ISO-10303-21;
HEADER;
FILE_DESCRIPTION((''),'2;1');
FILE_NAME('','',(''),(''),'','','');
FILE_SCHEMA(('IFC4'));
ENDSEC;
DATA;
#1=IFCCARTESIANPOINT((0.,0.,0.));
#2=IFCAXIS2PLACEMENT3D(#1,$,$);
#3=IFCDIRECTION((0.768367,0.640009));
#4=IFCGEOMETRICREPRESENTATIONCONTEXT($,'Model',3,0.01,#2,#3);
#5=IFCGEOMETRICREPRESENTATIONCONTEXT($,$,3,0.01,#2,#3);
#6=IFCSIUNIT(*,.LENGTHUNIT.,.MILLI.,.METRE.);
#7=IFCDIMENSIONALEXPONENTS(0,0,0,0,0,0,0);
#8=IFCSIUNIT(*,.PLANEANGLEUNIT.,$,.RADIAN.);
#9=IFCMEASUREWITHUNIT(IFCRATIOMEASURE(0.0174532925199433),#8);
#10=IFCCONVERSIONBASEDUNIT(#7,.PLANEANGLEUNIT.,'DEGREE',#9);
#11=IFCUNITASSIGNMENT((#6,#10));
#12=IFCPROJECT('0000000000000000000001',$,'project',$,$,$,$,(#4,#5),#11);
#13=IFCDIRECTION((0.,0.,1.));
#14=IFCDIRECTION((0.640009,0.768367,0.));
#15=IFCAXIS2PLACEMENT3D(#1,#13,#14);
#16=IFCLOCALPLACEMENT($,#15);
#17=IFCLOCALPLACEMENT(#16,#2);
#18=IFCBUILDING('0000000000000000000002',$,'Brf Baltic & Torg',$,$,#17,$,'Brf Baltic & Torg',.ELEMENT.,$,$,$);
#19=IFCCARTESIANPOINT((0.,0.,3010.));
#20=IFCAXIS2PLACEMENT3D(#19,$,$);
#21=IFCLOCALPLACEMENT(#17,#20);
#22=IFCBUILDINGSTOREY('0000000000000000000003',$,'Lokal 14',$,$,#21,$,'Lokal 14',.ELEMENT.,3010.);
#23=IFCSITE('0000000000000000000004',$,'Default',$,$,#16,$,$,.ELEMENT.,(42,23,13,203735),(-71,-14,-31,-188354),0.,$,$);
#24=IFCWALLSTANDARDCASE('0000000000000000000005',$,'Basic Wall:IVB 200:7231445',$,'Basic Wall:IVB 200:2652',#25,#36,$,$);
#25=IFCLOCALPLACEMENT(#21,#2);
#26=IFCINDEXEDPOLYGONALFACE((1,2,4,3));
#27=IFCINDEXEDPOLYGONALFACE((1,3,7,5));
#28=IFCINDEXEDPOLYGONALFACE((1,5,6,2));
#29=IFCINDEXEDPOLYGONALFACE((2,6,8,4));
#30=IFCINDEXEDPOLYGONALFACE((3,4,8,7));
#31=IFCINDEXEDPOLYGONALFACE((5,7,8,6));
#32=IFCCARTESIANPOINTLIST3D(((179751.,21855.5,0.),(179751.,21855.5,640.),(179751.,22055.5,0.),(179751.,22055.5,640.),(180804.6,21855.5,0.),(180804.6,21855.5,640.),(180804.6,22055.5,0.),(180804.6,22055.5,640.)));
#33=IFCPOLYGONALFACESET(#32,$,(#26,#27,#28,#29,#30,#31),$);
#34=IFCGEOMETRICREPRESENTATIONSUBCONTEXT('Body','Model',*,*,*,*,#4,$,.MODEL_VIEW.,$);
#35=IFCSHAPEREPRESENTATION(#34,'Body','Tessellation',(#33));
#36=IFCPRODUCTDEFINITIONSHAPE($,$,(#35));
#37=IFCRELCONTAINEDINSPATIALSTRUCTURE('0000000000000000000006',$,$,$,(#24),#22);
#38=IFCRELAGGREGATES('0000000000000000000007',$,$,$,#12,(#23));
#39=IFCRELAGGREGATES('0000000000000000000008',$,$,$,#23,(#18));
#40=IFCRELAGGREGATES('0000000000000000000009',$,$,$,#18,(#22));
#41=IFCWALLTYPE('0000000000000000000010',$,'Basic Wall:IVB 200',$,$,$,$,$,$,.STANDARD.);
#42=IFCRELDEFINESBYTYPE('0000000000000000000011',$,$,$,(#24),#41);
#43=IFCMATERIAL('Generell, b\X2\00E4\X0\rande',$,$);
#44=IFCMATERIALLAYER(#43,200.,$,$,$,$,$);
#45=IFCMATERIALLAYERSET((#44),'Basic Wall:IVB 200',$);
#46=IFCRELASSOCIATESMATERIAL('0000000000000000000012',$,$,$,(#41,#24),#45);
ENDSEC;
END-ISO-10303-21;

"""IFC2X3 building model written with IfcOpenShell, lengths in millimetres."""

from ifc_helpers import new_model, entity, si_unit, converted_unit, direction, frame, frame_2d, origin, place, context, subcontext, project, spatial, rectangle, extrude, clip, halfspace, material, layer, layer_set, layer_usage, type_object, element, save


model = new_model("IFC2X3")

# Units and contexts
model_context = context("Model", 3, precision=0.01, world=origin(), true_north=direction((0.768367, 0.640009)))
context_of_model = context(None, 3, precision=0.01, world=origin(), true_north=direction((0.768367, 0.640009)))
body_context = subcontext(model_context, "Body", "Model", "MODEL_VIEW")
ifc_project = project(units=[si_unit("LENGTHUNIT", "METRE", prefix="MILLI"), converted_unit("PLANEANGLEUNIT", "DEGREE", entity("IfcRatioMeasure", 0.0174532925199433), si_unit("PLANEANGLEUNIT", "RADIAN"), dimensions=[0, 0, 0, 0, 0, 0, 0])], contexts=[model_context, context_of_model])

# Site, building, storey
site_placement = place(None, frame((0.0, 0.0, 0.0), z_axis=(0.0, 0.0, 1.0), x_axis=(0.640009, 0.768367, 0.0)))
site = spatial("IfcSite", under=ifc_project, at=site_placement, Name="Default", CompositionType="ELEMENT", RefLatitude=(42, 23, 13, 203735), RefLongitude=(-71, -14, -31, -188354), RefElevation=0.0)
building_placement = place(site_placement, origin())
building = spatial("IfcBuilding", under=site, at=building_placement, Name="Brf Baltic & Torg", LongName="Brf Baltic & Torg", CompositionType="ELEMENT")
storey_placement = place(building_placement, frame((0.0, 0.0, 3010.0)))
storey = spatial("IfcBuildingStorey", under=building, at=storey_placement, Name="Lokal 14", LongName="Lokal 14", CompositionType="ELEMENT", Elevation=3010.0)

# Shared definitions
ifc_material = material(Name="Generell, bärande")
ifc_layer = layer(ifc_material, 200.0)
ifc_layer_set = layer_set([ifc_layer], Name="Basic Wall:IVB 200")
wall_type = type_object("IfcWallType", Name="Basic Wall:IVB 200", PredefinedType="STANDARD", material=ifc_layer_set)

# Wall
ifc_layer_usage_1 = layer_usage(ifc_layer_set, "AXIS2", "NEGATIVE", 100.0)
wall_1_placement = place(storey_placement, frame((179751.0, 21955.5, 0.0)))
element("IfcWallStandardCase", 1, at=wall_1_placement, inside=storey, type_object=wall_type, material=ifc_layer_usage_1, Name="Basic Wall:IVB 200:7231445", ObjectType="Basic Wall:IVB 200:2652", context=body_context, shape_type="Clipping", body=[
    clip(extrude(rectangle(XDim=1053.6, YDim=200.0, at=frame_2d((526.8, 0.0), x_axis=(-1.0, 0.0))), origin(), (0.0, 0.0, 1.0), 640.0), halfspace(frame((0.0, 0.0, -1360.0)), True)),
])

save(model, "model.ifc")
